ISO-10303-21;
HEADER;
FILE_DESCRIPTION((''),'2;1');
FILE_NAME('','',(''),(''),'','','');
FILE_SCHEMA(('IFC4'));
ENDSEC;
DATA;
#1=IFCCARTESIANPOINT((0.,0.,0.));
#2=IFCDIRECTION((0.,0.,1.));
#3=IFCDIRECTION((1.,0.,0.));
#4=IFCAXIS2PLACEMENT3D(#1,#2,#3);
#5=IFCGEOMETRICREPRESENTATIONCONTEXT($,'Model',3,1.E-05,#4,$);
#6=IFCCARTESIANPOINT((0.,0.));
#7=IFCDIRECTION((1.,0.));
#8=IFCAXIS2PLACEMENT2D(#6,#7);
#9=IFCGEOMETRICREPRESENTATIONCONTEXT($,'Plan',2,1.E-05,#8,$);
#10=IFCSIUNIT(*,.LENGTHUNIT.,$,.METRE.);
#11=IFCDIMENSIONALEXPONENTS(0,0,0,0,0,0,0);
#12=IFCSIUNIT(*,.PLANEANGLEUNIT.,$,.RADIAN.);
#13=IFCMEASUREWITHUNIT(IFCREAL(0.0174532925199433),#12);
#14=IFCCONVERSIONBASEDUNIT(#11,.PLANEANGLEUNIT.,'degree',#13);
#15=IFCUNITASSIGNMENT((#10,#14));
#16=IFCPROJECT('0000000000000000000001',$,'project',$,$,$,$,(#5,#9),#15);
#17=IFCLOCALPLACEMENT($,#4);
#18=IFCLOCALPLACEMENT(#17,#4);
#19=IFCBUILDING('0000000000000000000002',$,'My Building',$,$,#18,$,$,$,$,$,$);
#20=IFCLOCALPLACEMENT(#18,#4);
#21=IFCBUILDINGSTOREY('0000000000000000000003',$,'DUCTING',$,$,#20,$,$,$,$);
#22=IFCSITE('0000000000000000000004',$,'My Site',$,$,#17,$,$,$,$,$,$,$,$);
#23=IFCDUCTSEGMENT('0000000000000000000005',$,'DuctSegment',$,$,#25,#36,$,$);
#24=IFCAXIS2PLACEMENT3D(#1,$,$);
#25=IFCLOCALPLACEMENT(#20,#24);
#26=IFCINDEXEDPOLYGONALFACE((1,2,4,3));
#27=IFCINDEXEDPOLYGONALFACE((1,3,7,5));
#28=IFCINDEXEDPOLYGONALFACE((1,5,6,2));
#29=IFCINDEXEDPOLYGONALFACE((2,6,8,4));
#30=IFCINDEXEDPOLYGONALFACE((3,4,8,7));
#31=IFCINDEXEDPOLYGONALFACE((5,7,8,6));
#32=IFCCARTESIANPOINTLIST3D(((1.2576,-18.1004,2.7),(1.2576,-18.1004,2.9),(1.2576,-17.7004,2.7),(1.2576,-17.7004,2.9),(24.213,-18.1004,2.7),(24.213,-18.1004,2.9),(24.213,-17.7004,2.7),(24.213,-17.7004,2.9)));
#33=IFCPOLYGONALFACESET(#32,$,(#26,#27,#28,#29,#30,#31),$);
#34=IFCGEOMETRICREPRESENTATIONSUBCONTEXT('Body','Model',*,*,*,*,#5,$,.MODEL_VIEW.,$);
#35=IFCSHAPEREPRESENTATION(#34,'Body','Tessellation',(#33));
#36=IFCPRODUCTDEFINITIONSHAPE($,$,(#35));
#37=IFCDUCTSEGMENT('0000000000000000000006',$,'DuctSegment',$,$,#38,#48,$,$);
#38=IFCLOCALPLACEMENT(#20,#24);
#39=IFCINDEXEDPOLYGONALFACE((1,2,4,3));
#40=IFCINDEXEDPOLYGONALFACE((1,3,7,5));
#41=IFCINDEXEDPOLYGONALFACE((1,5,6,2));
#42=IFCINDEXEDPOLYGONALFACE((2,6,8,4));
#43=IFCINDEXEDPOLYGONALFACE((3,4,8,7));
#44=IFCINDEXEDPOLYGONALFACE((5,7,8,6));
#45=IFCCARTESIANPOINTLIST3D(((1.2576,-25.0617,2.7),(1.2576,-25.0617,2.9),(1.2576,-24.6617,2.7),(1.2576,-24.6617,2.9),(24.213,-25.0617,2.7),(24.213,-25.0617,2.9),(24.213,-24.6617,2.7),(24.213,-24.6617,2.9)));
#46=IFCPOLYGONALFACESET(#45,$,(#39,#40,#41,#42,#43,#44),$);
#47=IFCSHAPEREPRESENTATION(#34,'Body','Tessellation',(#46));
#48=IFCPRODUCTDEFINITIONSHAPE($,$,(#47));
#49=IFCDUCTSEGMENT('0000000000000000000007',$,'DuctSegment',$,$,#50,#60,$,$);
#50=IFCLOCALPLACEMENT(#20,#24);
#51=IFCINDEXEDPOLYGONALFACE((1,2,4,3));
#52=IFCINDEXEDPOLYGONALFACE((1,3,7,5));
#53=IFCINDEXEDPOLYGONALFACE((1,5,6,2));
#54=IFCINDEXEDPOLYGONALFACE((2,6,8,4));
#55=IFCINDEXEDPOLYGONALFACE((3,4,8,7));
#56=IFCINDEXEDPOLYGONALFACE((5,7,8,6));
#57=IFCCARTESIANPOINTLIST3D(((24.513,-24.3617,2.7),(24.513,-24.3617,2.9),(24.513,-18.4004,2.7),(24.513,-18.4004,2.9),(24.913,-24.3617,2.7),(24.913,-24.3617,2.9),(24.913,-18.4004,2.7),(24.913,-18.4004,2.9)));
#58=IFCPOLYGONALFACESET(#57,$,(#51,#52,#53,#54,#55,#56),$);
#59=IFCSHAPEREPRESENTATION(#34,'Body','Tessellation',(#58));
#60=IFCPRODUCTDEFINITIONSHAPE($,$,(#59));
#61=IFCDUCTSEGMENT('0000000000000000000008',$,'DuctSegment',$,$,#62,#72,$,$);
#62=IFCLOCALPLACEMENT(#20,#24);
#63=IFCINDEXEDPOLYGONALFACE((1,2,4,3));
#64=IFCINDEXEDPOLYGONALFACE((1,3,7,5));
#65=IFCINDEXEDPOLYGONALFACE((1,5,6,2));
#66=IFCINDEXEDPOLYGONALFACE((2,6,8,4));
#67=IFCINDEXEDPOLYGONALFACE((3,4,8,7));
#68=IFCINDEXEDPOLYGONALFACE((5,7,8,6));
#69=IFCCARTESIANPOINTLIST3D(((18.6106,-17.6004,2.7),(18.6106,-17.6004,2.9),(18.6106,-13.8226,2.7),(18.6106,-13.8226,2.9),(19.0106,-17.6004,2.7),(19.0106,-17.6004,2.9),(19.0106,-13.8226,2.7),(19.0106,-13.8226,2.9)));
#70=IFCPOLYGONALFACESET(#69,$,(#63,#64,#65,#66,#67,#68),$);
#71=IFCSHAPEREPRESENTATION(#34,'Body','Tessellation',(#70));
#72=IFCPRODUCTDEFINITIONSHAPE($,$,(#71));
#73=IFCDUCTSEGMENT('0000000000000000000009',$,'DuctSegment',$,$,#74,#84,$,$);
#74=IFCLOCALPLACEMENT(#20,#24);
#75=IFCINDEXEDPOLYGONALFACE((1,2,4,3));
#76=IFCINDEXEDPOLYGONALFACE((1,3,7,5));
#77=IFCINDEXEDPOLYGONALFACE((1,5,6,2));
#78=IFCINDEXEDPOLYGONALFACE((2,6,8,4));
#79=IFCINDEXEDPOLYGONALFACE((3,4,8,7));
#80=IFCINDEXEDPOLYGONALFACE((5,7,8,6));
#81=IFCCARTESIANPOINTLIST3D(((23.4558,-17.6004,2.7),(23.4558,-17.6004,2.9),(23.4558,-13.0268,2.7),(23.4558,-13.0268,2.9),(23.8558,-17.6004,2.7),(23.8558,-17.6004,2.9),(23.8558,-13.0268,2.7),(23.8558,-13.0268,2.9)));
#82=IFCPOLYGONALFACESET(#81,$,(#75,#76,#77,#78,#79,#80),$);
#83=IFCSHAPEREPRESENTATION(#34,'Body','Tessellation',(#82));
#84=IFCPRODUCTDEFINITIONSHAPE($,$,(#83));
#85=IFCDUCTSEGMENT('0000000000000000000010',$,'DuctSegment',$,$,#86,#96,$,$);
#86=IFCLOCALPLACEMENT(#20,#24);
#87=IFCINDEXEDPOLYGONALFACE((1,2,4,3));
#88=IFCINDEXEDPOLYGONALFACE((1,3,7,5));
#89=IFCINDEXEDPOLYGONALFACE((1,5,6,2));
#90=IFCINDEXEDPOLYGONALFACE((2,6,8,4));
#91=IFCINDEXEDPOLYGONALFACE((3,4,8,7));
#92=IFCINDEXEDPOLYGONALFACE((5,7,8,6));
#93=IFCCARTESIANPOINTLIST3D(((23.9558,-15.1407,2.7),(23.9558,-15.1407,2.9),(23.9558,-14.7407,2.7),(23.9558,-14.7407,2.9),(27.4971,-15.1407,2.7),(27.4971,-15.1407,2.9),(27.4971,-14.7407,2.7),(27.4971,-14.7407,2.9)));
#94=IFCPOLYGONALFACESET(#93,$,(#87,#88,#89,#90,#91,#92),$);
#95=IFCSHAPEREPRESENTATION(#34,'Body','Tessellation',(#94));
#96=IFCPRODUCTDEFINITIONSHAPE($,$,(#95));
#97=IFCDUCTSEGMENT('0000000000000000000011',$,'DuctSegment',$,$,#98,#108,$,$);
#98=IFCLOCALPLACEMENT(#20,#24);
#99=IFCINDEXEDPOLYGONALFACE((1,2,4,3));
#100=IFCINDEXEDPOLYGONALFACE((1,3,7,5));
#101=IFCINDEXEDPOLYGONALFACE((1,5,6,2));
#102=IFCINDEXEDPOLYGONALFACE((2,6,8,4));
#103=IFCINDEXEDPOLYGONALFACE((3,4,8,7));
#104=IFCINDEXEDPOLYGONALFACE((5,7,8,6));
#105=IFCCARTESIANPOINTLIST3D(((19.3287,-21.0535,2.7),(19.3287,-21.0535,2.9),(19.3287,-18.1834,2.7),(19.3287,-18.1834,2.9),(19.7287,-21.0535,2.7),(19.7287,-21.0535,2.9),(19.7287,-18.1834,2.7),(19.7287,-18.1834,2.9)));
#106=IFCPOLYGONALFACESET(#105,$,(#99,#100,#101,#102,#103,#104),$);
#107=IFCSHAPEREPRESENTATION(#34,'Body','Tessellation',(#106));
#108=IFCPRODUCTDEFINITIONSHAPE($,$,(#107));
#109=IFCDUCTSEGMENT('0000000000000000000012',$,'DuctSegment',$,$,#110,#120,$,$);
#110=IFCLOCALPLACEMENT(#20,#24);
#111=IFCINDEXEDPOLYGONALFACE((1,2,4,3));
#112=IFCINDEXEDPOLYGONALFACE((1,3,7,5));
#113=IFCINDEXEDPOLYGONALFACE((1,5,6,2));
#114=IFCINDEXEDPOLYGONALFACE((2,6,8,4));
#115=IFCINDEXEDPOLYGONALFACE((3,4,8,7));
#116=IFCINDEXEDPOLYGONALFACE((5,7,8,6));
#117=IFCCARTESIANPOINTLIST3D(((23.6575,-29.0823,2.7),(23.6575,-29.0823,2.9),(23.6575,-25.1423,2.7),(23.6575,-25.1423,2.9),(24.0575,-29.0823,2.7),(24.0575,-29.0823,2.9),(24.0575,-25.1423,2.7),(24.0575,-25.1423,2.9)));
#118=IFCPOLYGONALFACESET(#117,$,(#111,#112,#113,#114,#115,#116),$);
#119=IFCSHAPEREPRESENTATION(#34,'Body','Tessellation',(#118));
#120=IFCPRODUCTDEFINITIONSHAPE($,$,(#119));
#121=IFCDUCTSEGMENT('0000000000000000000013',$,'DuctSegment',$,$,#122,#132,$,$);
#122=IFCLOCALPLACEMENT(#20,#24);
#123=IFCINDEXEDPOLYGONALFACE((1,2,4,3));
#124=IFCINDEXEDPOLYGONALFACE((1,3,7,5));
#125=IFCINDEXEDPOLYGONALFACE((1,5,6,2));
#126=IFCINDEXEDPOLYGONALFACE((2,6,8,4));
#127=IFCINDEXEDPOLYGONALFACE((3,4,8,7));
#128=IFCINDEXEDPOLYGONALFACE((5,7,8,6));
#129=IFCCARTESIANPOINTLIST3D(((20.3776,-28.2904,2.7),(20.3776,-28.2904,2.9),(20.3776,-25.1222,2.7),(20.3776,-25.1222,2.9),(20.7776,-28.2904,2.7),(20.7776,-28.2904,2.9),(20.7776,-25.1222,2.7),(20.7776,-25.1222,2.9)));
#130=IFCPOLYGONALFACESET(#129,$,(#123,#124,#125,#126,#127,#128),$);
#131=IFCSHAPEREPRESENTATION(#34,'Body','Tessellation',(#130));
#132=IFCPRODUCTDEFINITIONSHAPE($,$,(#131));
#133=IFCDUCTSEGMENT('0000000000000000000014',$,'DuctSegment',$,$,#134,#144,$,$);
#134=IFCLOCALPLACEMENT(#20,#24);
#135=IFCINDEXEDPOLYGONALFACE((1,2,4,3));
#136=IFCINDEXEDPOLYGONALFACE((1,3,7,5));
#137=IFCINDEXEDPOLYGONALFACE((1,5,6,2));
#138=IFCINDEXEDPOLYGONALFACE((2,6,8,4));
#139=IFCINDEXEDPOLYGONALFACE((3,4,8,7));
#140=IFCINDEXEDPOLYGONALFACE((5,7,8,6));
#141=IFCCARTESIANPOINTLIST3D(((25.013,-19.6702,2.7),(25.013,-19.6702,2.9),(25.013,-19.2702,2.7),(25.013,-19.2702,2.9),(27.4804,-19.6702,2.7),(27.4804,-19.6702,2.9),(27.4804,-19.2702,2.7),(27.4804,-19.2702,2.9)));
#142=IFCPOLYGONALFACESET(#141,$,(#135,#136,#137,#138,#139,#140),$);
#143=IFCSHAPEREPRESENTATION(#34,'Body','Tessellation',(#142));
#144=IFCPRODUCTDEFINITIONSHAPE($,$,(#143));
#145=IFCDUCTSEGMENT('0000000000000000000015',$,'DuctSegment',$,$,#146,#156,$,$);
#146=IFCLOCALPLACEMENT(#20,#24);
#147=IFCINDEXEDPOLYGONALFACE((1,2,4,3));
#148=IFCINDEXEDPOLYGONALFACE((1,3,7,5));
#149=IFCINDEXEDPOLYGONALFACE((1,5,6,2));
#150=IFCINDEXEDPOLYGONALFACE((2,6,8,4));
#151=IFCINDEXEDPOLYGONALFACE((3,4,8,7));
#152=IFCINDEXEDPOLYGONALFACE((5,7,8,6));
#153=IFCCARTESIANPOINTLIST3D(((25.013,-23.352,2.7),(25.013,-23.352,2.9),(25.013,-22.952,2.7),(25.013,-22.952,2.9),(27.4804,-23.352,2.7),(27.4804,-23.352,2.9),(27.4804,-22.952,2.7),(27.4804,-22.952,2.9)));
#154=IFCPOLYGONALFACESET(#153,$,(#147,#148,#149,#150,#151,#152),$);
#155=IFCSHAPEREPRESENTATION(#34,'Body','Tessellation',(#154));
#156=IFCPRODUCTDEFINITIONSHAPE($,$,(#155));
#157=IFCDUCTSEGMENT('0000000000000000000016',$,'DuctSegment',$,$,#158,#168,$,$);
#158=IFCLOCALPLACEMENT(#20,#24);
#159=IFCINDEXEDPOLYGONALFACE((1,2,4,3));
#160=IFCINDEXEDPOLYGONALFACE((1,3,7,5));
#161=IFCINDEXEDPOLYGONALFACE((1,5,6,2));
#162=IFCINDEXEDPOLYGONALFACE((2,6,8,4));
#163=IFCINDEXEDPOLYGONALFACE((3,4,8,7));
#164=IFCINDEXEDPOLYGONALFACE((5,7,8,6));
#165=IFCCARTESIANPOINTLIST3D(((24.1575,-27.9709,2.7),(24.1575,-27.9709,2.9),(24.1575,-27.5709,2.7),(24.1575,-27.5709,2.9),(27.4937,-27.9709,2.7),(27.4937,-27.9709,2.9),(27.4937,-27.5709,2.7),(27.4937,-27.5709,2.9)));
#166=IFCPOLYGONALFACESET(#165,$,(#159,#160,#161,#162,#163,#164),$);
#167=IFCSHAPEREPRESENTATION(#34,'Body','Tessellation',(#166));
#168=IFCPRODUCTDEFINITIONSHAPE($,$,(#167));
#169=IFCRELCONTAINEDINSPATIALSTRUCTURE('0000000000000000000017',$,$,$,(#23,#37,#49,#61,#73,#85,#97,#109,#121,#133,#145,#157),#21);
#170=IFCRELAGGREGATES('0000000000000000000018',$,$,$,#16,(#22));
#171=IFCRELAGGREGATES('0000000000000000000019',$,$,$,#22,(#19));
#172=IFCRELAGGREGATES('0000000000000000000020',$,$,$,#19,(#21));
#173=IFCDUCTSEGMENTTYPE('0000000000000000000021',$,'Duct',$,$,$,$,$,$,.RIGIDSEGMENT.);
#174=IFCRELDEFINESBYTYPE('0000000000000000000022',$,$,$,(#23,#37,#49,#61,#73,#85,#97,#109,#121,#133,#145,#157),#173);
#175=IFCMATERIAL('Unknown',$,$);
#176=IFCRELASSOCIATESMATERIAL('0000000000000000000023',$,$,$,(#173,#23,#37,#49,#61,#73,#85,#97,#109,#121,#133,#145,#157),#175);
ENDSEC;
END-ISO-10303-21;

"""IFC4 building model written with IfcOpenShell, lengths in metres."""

from ifc_helpers import new_model, entity, si_unit, converted_unit, frame, origin_with_axes, origin_2d_with_axis, place, context, subcontext, project, spatial, rectangle, extrude, material, material_profile, profile_set, profile_usage, type_object, element, save


model = new_model("IFC4")

# Units and contexts
model_context = context("Model", 3, precision=1e-05, world=origin_with_axes())
plan_context = context("Plan", 2, precision=1e-05, world=origin_2d_with_axis())
body_context = subcontext(model_context, "Body", "Model", "MODEL_VIEW")
ifc_project = project(units=[si_unit("LENGTHUNIT", "METRE"), converted_unit("PLANEANGLEUNIT", "degree", entity("IfcReal", 0.0174532925199433), si_unit("PLANEANGLEUNIT", "RADIAN"), dimensions=[0, 0, 0, 0, 0, 0, 0])], contexts=[model_context, plan_context])

# Site, building, storey
site_placement = place(None, origin_with_axes())
site = spatial("IfcSite", under=ifc_project, at=site_placement, Name="My Site")
building_placement = place(site_placement, origin_with_axes())
building = spatial("IfcBuilding", under=site, at=building_placement, Name="My Building")
storey_placement = place(building_placement, origin_with_axes())
storey = spatial("IfcBuildingStorey", under=building, at=storey_placement, Name="DUCTING")

# Duct segments
ifc_material = material(Name="Unknown")
ifc_material_profile_1 = material_profile(ifc_material, rectangle(XDim=0.4, YDim=0.2))
ifc_profile_set_1 = profile_set([ifc_material_profile_1])
ifc_profile_usage_1 = profile_usage(ifc_profile_set_1, cardinal=5)
duct_segment_type = type_object("IfcDuctSegmentType", Name="Duct", PredefinedType="RIGIDSEGMENT", material=ifc_profile_set_1)
duct_segment_1_placement = place(storey_placement, frame((24.213, -17.9004, 2.8), z_axis=(-1.0, 0.0, 0.0), x_axis=(0.0, -1.0, 0.0)))
element("IfcDuctSegment", 1, at=duct_segment_1_placement, inside=storey, type_object=duct_segment_type, material=ifc_profile_usage_1, Name="DuctSegment", context=body_context, shape_type="SweptSolid", body=[
    extrude(rectangle(XDim=0.4, YDim=0.2), origin_with_axes(), (0.0, 0.0, 1.0), 22.9554),
])
ifc_profile_usage_2 = profile_usage(ifc_profile_set_1, cardinal=5)
duct_segment_2_placement = place(storey_placement, frame((24.213, -24.8617, 2.8), z_axis=(-1.0, 0.0, 0.0), x_axis=(0.0, -1.0, 0.0)))
element("IfcDuctSegment", 2, at=duct_segment_2_placement, inside=storey, type_object=duct_segment_type, material=ifc_profile_usage_2, Name="DuctSegment", context=body_context, shape_type="SweptSolid", body=[
    extrude(rectangle(XDim=0.4, YDim=0.2), origin_with_axes(), (0.0, 0.0, 1.0), 22.9554),
])
ifc_profile_usage_3 = profile_usage(ifc_profile_set_1, cardinal=5)
duct_segment_3_placement = place(storey_placement, frame((24.713, -24.3617, 2.8), z_axis=(0.0, 1.0, 0.0), x_axis=(-1.0, 0.0, 0.0)))
element("IfcDuctSegment", 3, at=duct_segment_3_placement, inside=storey, type_object=duct_segment_type, material=ifc_profile_usage_3, Name="DuctSegment", context=body_context, shape_type="SweptSolid", body=[
    extrude(rectangle(XDim=0.4, YDim=0.2), origin_with_axes(), (0.0, 0.0, 1.0), 5.9613),
])
ifc_profile_usage_4 = profile_usage(ifc_profile_set_1, cardinal=5)
duct_segment_4_placement = place(storey_placement, frame((18.8106, -17.6004, 2.8), z_axis=(0.0, 1.0, 0.0), x_axis=(-1.0, 0.0, 0.0)))
element("IfcDuctSegment", 4, at=duct_segment_4_placement, inside=storey, type_object=duct_segment_type, material=ifc_profile_usage_4, Name="DuctSegment", context=body_context, shape_type="SweptSolid", body=[
    extrude(rectangle(XDim=0.4, YDim=0.2), origin_with_axes(), (0.0, 0.0, 1.0), 3.7777),
])
ifc_profile_usage_5 = profile_usage(ifc_profile_set_1, cardinal=5)
duct_segment_5_placement = place(storey_placement, frame((23.6558, -17.6004, 2.8), z_axis=(0.0, 1.0, 0.0), x_axis=(-1.0, 0.0, 0.0)))
element("IfcDuctSegment", 5, at=duct_segment_5_placement, inside=storey, type_object=duct_segment_type, material=ifc_profile_usage_5, Name="DuctSegment", context=body_context, shape_type="SweptSolid", body=[
    extrude(rectangle(XDim=0.4, YDim=0.2), origin_with_axes(), (0.0, 0.0, 1.0), 4.5736),
])
ifc_profile_usage_6 = profile_usage(ifc_profile_set_1, cardinal=5)
duct_segment_6_placement = place(storey_placement, frame((23.9558, -14.9407, 2.8), z_axis=(1.0, 0.0, 0.0), x_axis=(0.0, 1.0, 0.0)))
element("IfcDuctSegment", 6, at=duct_segment_6_placement, inside=storey, type_object=duct_segment_type, material=ifc_profile_usage_6, Name="DuctSegment", context=body_context, shape_type="SweptSolid", body=[
    extrude(rectangle(XDim=0.4, YDim=0.2), origin_with_axes(), (0.0, 0.0, 1.0), 3.5414),
])
ifc_profile_usage_7 = profile_usage(ifc_profile_set_1, cardinal=5)
duct_segment_7_placement = place(storey_placement, frame((19.5287, -21.0535, 2.8), z_axis=(-0.000001, 1.0, 0.0), x_axis=(-1.0, -0.000001, 0.0)))
element("IfcDuctSegment", 7, at=duct_segment_7_placement, inside=storey, type_object=duct_segment_type, material=ifc_profile_usage_7, Name="DuctSegment", context=body_context, shape_type="SweptSolid", body=[
    extrude(rectangle(XDim=0.4, YDim=0.2), origin_with_axes(), (0.0, 0.0, 1.0), 2.8701),
])
ifc_profile_usage_8 = profile_usage(ifc_profile_set_1, cardinal=5)
duct_segment_8_placement = place(storey_placement, frame((23.8575, -29.0823, 2.8), z_axis=(0.0, 1.0, 0.0), x_axis=(-1.0, 0.0, 0.0)))
element("IfcDuctSegment", 8, at=duct_segment_8_placement, inside=storey, type_object=duct_segment_type, material=ifc_profile_usage_8, Name="DuctSegment", context=body_context, shape_type="SweptSolid", body=[
    extrude(rectangle(XDim=0.4, YDim=0.2), origin_with_axes(), (0.0, 0.0, 1.0), 3.94),
])
ifc_profile_usage_9 = profile_usage(ifc_profile_set_1, cardinal=5)
duct_segment_9_placement = place(storey_placement, frame((20.5776, -28.2904, 2.8), z_axis=(0.0, 1.0, 0.0), x_axis=(-1.0, 0.0, 0.0)))
element("IfcDuctSegment", 9, at=duct_segment_9_placement, inside=storey, type_object=duct_segment_type, material=ifc_profile_usage_9, Name="DuctSegment", context=body_context, shape_type="SweptSolid", body=[
    extrude(rectangle(XDim=0.4, YDim=0.2), origin_with_axes(), (0.0, 0.0, 1.0), 3.1683),
])
ifc_profile_usage_10 = profile_usage(ifc_profile_set_1, cardinal=5)
duct_segment_10_placement = place(storey_placement, frame((25.013, -19.4702, 2.8), z_axis=(1.0, 0.000001, -0.000001), x_axis=(-0.000001, 1.0, 0.0)))
element("IfcDuctSegment", 10, at=duct_segment_10_placement, inside=storey, type_object=duct_segment_type, material=ifc_profile_usage_10, Name="DuctSegment", context=body_context, shape_type="SweptSolid", body=[
    extrude(rectangle(XDim=0.4, YDim=0.2), origin_with_axes(), (0.0, 0.0, 1.0), 2.4674),
])
ifc_profile_usage_11 = profile_usage(ifc_profile_set_1, cardinal=5)
duct_segment_11_placement = place(storey_placement, frame((25.013, -23.152, 2.8), z_axis=(1.0, 0.000001, -0.000001), x_axis=(-0.000001, 1.0, 0.0)))
element("IfcDuctSegment", 11, at=duct_segment_11_placement, inside=storey, type_object=duct_segment_type, material=ifc_profile_usage_11, Name="DuctSegment", context=body_context, shape_type="SweptSolid", body=[
    extrude(rectangle(XDim=0.4, YDim=0.2), origin_with_axes(), (0.0, 0.0, 1.0), 2.4674),
])
ifc_profile_usage_12 = profile_usage(ifc_profile_set_1, cardinal=5)
duct_segment_12_placement = place(storey_placement, frame((24.1575, -27.7709, 2.8), z_axis=(1.0, 0.0, 0.0), x_axis=(0.0, 1.0, 0.0)))
element("IfcDuctSegment", 12, at=duct_segment_12_placement, inside=storey, type_object=duct_segment_type, material=ifc_profile_usage_12, Name="DuctSegment", context=body_context, shape_type="SweptSolid", body=[
    extrude(rectangle(XDim=0.4, YDim=0.2), origin_with_axes(), (0.0, 0.0, 1.0), 3.3362),
])

save(model, "model.ifc")
